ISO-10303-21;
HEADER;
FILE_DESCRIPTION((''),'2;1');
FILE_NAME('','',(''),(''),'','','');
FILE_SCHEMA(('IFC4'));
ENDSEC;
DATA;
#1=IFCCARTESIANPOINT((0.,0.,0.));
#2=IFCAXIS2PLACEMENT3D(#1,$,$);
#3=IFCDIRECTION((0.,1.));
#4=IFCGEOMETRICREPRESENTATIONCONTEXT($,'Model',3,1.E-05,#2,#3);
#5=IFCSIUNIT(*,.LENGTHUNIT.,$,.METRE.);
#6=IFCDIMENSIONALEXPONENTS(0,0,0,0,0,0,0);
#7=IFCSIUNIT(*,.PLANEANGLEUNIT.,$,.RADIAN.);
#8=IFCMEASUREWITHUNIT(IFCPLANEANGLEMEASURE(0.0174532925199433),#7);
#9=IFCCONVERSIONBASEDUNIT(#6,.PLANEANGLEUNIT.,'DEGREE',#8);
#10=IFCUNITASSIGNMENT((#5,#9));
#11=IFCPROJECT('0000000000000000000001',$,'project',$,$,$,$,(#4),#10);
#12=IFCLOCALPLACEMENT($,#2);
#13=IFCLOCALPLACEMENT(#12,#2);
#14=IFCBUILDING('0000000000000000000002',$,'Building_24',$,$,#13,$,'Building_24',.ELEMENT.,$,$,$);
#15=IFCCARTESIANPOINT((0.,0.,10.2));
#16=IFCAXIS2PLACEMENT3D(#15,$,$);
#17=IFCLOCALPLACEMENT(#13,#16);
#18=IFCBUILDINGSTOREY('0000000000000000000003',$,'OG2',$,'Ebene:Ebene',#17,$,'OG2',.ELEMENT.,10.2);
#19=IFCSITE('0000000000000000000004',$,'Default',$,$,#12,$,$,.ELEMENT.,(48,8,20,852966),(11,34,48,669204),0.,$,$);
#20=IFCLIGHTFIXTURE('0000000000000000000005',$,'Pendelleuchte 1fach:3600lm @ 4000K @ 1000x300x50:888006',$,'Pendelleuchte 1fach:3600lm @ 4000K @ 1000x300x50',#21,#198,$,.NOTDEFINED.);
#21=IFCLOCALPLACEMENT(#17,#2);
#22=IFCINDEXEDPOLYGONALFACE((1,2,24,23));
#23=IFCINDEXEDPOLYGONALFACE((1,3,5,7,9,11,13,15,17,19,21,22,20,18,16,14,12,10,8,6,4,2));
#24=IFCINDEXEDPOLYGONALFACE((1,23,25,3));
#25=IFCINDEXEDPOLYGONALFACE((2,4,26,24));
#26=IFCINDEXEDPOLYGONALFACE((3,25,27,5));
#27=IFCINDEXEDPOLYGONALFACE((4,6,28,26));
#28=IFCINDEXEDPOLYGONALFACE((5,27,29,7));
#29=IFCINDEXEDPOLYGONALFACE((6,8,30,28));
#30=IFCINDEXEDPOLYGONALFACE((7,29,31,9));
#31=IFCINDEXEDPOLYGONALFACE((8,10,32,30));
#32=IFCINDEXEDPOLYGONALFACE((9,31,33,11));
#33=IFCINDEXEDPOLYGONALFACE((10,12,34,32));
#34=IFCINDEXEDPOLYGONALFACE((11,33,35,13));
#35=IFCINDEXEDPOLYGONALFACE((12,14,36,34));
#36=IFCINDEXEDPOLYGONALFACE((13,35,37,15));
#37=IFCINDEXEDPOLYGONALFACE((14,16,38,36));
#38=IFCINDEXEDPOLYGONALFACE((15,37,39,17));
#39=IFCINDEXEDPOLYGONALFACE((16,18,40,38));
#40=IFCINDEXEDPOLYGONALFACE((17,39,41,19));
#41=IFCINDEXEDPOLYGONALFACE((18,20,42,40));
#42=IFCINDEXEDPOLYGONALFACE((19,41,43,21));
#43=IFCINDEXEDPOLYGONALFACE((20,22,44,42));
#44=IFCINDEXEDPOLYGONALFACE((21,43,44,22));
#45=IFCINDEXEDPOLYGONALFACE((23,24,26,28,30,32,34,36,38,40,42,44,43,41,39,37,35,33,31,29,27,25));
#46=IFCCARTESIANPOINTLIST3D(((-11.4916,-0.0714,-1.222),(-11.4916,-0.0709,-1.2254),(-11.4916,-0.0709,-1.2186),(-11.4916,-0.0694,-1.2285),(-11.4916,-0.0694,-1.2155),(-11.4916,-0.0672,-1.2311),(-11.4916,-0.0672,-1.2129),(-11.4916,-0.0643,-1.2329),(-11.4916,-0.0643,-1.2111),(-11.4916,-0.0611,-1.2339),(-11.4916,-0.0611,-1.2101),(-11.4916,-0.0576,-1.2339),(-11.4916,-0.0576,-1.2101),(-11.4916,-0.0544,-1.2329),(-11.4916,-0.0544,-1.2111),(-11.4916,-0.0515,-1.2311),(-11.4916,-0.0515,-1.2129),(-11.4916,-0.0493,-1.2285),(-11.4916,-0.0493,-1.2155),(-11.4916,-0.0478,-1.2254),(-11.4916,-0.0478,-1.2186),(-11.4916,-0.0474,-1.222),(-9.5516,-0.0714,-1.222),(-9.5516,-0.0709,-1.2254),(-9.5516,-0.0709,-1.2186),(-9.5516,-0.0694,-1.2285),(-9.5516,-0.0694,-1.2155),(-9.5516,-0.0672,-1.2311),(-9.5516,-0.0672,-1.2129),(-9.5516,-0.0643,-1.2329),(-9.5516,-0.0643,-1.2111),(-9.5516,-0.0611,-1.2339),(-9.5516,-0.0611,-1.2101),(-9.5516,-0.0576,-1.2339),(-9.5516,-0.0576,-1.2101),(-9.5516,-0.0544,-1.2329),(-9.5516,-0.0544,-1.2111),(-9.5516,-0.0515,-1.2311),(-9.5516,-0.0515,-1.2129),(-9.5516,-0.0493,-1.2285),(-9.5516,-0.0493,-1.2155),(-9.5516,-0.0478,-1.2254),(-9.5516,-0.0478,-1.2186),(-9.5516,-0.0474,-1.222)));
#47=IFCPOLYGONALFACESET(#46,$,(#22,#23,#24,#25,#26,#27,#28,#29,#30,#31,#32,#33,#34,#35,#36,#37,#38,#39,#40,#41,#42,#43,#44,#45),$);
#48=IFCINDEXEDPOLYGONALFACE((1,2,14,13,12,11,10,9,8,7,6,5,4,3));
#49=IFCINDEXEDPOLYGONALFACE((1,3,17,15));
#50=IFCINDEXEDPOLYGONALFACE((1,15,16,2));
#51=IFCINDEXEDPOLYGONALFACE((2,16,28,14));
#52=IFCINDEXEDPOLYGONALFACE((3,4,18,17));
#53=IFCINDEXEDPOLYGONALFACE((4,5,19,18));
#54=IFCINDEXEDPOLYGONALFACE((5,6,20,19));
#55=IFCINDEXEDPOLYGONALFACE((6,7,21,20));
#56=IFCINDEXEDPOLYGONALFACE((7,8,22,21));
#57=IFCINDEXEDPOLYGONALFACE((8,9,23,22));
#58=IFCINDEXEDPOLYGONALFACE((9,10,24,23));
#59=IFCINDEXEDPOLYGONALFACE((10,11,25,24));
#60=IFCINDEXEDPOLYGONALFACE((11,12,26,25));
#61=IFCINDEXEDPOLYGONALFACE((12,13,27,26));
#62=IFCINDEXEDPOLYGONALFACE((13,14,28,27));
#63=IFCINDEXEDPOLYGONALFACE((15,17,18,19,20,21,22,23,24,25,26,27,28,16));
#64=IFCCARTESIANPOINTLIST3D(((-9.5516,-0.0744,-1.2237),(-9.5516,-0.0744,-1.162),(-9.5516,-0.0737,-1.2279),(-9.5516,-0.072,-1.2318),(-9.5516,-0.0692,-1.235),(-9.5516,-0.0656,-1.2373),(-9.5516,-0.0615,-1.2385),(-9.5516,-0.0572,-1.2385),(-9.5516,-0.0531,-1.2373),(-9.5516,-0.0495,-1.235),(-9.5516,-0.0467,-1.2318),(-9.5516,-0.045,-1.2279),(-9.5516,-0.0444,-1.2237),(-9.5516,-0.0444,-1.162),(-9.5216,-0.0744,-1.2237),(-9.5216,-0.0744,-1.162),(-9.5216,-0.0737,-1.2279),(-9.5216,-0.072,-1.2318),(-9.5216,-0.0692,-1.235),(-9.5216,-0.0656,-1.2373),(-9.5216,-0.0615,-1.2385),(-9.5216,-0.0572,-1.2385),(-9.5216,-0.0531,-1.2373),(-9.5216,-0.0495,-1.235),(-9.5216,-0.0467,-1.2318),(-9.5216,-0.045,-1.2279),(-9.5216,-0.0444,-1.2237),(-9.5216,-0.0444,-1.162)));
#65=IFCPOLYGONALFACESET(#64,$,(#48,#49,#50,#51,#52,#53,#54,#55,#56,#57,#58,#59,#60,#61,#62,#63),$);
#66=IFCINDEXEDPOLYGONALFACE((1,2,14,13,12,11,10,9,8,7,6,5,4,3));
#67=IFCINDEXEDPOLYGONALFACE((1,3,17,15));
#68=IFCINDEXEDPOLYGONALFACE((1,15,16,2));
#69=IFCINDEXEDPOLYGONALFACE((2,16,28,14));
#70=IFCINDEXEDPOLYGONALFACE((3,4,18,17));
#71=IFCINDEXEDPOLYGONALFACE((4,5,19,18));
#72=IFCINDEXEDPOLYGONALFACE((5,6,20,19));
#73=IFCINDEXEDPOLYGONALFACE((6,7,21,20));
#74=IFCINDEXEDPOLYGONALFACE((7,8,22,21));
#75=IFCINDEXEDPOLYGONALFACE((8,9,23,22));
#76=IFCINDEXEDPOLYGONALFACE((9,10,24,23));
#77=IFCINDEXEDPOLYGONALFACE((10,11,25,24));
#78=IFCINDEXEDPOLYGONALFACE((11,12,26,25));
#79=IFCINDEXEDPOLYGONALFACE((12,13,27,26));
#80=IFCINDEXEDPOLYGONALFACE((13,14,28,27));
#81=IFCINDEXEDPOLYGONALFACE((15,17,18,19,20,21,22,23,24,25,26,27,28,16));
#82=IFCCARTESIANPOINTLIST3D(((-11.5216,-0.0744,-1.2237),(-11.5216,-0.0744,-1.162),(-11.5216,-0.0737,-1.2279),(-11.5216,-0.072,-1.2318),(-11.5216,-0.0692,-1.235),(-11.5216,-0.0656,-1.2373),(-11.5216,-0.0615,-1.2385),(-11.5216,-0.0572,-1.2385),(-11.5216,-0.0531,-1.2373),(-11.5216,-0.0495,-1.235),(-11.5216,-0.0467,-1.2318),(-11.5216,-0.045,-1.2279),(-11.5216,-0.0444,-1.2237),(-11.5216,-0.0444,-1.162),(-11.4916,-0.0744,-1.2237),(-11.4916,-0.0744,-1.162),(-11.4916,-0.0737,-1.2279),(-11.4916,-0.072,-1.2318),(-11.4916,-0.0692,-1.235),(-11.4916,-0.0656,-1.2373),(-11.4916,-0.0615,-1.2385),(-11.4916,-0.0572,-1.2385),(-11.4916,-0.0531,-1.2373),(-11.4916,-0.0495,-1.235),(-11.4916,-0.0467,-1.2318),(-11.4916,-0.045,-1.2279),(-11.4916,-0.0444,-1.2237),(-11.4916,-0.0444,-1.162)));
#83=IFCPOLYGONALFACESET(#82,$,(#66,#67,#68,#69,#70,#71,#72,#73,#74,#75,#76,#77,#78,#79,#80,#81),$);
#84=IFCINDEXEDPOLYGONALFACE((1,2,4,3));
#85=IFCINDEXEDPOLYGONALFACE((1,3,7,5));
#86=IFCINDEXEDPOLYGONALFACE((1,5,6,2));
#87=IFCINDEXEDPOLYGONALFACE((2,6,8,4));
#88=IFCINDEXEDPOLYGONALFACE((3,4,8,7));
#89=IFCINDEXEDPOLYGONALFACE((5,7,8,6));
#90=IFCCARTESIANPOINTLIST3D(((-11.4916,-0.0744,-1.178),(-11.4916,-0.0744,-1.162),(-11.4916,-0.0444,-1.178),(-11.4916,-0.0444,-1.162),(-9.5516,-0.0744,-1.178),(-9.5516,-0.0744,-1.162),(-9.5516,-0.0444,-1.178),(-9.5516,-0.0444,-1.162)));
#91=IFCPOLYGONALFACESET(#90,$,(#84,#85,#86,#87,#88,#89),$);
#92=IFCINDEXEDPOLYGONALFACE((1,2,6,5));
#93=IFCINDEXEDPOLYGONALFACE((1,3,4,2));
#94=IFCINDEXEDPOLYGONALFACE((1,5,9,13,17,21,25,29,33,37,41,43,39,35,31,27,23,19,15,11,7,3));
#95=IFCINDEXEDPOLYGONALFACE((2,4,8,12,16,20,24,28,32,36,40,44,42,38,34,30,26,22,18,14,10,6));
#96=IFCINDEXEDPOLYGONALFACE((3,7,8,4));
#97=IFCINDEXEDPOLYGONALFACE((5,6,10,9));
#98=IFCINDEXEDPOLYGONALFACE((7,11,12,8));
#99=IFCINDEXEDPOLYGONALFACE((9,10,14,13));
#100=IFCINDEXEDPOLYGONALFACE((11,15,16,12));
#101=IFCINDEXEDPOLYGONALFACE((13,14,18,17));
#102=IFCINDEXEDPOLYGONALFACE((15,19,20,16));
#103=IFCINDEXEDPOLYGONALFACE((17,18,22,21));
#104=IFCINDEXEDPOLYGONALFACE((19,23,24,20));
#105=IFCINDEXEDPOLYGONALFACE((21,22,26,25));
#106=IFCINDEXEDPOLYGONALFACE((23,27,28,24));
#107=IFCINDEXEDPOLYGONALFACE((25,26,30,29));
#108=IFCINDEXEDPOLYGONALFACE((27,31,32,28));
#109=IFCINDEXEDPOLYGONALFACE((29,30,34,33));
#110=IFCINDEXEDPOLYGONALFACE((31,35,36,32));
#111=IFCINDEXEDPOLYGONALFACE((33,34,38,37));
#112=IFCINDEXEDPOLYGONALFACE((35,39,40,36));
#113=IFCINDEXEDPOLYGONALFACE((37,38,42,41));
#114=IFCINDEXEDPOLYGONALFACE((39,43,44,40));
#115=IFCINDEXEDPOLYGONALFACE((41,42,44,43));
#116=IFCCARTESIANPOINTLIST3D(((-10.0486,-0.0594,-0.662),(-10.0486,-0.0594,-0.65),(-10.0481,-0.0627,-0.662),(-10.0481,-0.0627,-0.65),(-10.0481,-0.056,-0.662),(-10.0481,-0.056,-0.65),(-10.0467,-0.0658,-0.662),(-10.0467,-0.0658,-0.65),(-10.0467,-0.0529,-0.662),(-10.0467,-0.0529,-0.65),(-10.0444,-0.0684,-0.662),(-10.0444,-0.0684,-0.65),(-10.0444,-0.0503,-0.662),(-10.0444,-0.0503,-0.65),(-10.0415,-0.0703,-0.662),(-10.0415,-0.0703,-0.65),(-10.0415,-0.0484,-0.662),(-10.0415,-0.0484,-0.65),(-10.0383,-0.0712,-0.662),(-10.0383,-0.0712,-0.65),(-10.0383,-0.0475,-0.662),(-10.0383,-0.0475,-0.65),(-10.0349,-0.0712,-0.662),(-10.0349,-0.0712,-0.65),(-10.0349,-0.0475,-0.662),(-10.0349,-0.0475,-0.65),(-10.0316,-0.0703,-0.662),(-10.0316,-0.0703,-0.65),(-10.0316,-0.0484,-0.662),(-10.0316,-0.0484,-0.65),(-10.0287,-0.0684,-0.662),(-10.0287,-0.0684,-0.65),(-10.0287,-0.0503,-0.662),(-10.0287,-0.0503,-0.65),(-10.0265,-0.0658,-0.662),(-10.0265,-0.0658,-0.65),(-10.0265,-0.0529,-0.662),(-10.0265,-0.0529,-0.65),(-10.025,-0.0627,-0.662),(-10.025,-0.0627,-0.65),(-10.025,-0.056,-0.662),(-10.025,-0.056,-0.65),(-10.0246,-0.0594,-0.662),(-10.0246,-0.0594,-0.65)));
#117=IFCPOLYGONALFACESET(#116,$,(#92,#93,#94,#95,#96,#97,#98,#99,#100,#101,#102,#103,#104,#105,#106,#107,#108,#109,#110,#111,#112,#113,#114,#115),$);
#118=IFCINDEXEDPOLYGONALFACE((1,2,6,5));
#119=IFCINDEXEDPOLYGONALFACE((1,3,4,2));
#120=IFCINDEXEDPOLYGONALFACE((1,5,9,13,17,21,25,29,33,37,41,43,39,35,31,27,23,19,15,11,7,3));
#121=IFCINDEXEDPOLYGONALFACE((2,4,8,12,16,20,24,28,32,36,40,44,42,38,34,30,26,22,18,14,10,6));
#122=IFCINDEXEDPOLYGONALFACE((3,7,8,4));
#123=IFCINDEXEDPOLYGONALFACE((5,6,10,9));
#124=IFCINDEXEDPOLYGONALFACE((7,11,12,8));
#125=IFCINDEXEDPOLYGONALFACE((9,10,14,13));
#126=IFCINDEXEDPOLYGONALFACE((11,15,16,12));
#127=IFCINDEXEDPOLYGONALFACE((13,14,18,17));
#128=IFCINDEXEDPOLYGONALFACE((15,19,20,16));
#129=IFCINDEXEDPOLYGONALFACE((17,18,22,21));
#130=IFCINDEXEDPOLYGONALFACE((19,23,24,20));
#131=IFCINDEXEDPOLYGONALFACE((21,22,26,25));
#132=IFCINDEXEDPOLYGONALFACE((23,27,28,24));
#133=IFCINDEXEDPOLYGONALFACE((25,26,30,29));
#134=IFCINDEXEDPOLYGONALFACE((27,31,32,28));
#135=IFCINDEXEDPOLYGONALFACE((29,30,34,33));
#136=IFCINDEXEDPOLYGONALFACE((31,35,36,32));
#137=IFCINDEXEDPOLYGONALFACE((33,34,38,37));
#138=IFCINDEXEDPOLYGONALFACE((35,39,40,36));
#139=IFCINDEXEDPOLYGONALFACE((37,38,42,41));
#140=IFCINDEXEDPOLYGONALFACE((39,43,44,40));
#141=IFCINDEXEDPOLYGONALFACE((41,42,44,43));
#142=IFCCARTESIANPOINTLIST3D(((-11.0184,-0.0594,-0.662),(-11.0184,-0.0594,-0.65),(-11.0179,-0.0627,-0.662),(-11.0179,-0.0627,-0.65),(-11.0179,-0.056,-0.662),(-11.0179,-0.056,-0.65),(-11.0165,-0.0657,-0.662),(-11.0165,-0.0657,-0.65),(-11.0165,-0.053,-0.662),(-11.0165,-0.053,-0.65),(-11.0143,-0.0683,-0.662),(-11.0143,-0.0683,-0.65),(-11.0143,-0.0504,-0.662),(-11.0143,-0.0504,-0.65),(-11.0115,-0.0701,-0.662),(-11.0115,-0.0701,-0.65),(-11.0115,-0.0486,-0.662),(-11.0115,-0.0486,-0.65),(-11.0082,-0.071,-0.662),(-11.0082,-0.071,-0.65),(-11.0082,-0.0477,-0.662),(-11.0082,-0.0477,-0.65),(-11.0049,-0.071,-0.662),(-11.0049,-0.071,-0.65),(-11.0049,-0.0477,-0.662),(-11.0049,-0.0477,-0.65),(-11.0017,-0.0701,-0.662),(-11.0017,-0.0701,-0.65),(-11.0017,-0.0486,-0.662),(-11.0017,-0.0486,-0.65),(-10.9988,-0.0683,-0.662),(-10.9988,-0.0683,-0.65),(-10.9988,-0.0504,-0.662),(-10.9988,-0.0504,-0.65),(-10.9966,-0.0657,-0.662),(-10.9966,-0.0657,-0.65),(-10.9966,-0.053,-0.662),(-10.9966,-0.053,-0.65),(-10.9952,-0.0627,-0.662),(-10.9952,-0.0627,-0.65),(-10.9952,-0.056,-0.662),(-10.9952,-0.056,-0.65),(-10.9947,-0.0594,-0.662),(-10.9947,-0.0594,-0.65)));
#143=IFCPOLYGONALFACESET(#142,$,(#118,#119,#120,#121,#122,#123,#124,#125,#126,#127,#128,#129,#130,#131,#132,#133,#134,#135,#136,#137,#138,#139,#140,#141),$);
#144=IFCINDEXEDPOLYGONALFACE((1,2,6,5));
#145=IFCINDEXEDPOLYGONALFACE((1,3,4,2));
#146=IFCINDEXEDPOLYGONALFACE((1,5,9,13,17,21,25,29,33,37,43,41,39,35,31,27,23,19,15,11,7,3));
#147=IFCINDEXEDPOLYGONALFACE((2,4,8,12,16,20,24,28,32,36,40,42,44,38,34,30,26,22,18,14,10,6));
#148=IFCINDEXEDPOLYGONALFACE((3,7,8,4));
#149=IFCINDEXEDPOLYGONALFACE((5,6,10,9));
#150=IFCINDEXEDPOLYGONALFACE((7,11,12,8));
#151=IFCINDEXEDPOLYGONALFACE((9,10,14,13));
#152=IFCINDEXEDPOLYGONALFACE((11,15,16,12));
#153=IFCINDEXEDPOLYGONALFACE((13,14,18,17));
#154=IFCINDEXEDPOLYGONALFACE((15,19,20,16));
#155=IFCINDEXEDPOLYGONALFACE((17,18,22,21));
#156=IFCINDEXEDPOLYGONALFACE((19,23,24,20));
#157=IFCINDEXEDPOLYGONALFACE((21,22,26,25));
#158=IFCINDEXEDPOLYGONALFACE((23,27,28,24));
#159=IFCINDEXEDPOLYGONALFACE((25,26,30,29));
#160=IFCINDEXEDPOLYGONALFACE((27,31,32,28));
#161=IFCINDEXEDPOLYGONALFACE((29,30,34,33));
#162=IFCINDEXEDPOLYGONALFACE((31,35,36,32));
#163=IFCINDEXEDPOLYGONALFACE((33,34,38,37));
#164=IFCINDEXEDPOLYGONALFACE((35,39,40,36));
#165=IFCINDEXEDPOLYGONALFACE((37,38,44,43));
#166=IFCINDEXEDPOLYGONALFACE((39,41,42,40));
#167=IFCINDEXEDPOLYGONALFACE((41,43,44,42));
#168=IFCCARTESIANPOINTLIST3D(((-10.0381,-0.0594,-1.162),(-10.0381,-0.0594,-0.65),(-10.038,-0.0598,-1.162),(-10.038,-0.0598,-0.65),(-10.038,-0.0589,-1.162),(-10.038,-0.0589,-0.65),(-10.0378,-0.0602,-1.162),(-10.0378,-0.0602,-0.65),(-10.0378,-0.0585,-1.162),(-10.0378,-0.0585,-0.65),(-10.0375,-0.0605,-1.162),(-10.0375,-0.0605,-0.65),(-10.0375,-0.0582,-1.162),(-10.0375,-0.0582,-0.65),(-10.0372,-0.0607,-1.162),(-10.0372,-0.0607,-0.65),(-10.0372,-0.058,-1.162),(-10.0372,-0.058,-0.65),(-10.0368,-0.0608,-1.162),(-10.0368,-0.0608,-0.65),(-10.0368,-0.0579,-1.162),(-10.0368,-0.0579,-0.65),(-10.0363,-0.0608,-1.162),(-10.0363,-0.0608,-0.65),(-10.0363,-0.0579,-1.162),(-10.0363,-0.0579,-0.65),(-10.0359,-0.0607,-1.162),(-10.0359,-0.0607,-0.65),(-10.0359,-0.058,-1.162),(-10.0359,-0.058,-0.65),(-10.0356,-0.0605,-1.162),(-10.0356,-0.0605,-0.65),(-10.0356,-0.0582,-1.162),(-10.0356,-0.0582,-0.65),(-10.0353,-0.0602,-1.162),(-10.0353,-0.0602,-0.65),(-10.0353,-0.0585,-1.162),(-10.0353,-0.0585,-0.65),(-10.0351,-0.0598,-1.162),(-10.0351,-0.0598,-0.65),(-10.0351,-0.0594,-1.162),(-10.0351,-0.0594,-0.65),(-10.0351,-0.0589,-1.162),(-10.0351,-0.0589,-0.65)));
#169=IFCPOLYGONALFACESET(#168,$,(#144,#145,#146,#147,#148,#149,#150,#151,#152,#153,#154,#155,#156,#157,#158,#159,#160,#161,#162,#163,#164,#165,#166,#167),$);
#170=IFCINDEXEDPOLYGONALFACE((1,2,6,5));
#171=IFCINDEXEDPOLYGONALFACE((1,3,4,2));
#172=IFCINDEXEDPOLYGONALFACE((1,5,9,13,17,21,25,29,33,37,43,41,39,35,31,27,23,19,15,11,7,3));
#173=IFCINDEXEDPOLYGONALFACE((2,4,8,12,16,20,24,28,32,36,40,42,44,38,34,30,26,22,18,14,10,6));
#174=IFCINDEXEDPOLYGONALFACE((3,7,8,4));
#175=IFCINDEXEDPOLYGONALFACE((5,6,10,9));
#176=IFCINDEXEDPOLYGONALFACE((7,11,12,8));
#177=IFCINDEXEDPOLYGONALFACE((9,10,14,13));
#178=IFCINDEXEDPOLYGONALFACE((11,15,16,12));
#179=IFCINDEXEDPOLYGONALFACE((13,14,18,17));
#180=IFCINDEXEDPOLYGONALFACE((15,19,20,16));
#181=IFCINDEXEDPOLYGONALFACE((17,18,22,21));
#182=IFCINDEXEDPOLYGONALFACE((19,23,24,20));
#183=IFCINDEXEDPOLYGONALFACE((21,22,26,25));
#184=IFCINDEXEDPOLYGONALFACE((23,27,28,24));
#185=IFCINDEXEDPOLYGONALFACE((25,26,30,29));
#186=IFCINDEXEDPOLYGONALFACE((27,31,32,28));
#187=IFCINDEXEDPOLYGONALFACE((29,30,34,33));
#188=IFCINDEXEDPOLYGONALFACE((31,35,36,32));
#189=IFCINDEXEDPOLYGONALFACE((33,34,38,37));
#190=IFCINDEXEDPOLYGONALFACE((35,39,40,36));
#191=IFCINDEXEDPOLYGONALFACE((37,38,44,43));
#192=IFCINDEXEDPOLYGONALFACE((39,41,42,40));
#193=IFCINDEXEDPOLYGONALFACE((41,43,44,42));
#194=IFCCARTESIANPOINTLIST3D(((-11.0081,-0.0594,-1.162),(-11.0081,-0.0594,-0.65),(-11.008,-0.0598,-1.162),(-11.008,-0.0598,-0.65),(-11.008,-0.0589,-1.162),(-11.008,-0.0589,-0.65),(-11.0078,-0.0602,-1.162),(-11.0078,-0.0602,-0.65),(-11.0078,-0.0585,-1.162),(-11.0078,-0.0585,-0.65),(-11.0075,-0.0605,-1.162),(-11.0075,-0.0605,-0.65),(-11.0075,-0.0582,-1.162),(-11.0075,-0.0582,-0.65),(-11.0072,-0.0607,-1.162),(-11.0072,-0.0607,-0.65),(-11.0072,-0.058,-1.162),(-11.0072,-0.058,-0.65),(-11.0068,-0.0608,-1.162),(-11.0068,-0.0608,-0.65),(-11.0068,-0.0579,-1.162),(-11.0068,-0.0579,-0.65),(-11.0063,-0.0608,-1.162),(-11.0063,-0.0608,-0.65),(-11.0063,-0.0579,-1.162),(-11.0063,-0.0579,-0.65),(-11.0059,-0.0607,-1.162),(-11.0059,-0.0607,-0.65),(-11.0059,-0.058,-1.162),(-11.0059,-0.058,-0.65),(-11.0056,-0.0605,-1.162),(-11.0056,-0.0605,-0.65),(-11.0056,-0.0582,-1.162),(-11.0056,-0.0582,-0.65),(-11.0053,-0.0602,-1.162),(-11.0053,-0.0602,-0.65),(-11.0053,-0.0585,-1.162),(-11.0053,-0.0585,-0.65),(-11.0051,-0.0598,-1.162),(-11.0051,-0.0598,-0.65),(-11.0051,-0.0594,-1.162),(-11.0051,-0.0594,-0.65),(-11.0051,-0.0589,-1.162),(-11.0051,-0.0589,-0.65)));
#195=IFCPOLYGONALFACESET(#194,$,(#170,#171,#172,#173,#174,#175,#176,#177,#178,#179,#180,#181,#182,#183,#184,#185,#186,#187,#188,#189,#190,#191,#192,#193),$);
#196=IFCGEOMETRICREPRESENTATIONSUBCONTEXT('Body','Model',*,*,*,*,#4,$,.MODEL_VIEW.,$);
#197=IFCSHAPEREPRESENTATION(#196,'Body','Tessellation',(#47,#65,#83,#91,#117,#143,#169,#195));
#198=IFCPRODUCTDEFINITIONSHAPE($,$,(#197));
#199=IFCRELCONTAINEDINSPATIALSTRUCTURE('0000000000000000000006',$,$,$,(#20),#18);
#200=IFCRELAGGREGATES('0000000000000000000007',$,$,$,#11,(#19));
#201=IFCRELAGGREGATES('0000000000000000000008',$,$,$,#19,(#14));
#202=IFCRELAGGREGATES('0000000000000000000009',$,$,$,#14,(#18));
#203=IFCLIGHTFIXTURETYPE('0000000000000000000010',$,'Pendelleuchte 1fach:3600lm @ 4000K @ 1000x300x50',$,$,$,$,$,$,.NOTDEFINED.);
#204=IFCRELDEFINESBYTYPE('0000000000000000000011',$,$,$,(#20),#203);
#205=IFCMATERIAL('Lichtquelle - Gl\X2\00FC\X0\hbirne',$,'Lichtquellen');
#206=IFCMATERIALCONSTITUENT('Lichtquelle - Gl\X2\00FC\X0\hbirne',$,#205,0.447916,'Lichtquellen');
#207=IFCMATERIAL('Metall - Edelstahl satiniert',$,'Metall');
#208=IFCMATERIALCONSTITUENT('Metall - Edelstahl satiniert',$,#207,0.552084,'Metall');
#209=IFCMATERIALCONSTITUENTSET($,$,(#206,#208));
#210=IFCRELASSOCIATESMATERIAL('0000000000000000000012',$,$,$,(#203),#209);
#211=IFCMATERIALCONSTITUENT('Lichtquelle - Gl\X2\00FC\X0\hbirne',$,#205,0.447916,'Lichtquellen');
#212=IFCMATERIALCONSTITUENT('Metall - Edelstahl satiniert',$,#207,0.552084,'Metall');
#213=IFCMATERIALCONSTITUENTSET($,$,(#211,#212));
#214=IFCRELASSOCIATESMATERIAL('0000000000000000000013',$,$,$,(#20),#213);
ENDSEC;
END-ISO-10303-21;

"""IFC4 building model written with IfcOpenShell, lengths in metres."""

from ifc_helpers import new_model, entity, si_unit, converted_unit, direction, frame, origin, place, context, subcontext, project, spatial, line, arc, indexed_curve, outline, extrude, source, transform, mapped, material, constituent, constituent_set, type_object, type_shapes, element, save


model = new_model("IFC4")

# Units and contexts
model_context = context("Model", 3, precision=1e-05, world=origin(), true_north=direction((0.0, 1.0)))
body_context = subcontext(model_context, "Body", "Model", "MODEL_VIEW")
ifc_project = project(units=[si_unit("LENGTHUNIT", "METRE"), converted_unit("PLANEANGLEUNIT", "DEGREE", entity("IfcPlaneAngleMeasure", 0.0174532925199433), si_unit("PLANEANGLEUNIT", "RADIAN"), dimensions=[0, 0, 0, 0, 0, 0, 0])], contexts=[model_context])

# Site, building, storey
site_placement = place(None, origin())
site = spatial("IfcSite", under=ifc_project, at=site_placement, Name="Default", CompositionType="ELEMENT", RefLatitude=(48, 8, 20, 852966), RefLongitude=(11, 34, 48, 669204), RefElevation=0.0)
building_placement = place(site_placement, origin())
building = spatial("IfcBuilding", under=site, at=building_placement, Name="Building_24", LongName="Building_24", CompositionType="ELEMENT")
storey_placement = place(building_placement, frame((0.0, 0.0, 10.2)))
storey = spatial("IfcBuildingStorey", under=building, at=storey_placement, Name="OG2", ObjectType="Ebene:Ebene", LongName="OG2", CompositionType="ELEMENT", Elevation=10.2)

# Light fixture
ifc_material_1 = material(Name="Lichtquelle - Glühbirne", Category="Lichtquellen")
ifc_material_2 = material(Name="Metall - Edelstahl satiniert", Category="Metall")
ifc_constituent_1 = constituent(ifc_material_1, Name="Lichtquelle - Glühbirne", Category="Lichtquellen", fraction=0.447916)
ifc_constituent_2 = constituent(ifc_material_2, Name="Metall - Edelstahl satiniert", Category="Metall", fraction=0.552084)
ifc_constituent_set_1 = constituent_set(constituents=[ifc_constituent_1, ifc_constituent_2])
light_fixture_type_1 = type_object("IfcLightFixtureType", Name="Pendelleuchte 1fach:3600lm @ 4000K @ 1000x300x50", PredefinedType="NOTDEFINED", material=ifc_constituent_set_1)
shared_shape_1 = source(origin(), body_context, "Body", "SweptSolid", [
    extrude(outline(indexed_curve([(-0.012, 0.0), (0.0, -0.012), (0.012, 0.0), (0.0, 0.012)], segments=[arc(1, 2, 3), arc(3, 4, 1)], self_intersect=False)), frame((-0.97, 0.0, -0.572), z_axis=(1.0, 0.0, 0.0), x_axis=(0.0, 1.0, 0.0)), (0.0, 0.0, 1.0), 1.94),
    extrude(outline(indexed_curve([(-0.0308, -0.015), (0.0308, -0.015), (0.0308, 0.015), (-0.0308, 0.015), (-0.0458, 0.0)], segments=[line(1, 2, 3, 4), arc(4, 5, 1)], self_intersect=False)), frame((0.97, 0.0, -0.5428), z_axis=(1.0, 0.0, 0.0), x_axis=(0.0, 0.0, 1.0)), (0.0, 0.0, 1.0), 0.03),
    extrude(outline(indexed_curve([(-0.0308, -0.015), (0.0308, -0.015), (0.0308, 0.015), (-0.0308, 0.015), (-0.0458, 0.0)], segments=[line(1, 2, 3, 4), arc(4, 5, 1)], self_intersect=False)), frame((-1.0, 0.0, -0.5428), z_axis=(1.0, 0.0, 0.0), x_axis=(0.0, 0.0, 1.0)), (0.0, 0.0, 1.0), 0.03),
    extrude(outline(indexed_curve([(-0.97, -0.015), (0.97, -0.015), (0.97, 0.015), (-0.97, 0.015), (-0.97, -0.015)], self_intersect=False)), frame((0.0, 0.0, -0.528), z_axis=(0.0, 0.0, 1.0), x_axis=(-1.0, 0.0, 0.0)), (0.0, 0.0, 1.0), 0.016),
    extrude(outline(indexed_curve([(-0.012, 0.0), (0.0, -0.012), (0.012, 0.0), (0.0, 0.012)], segments=[arc(1, 2, 3), arc(3, 4, 1)], self_intersect=False)), frame((0.485, 0.0, -0.012)), (0.0, 0.0, 1.0), 0.012),
    extrude(outline(indexed_curve([(-0.0118, 0.0), (0.0, -0.0118), (0.0118, 0.0), (0.0, 0.0118)], segments=[arc(1, 2, 3), arc(3, 4, 1)], self_intersect=False)), frame((-0.485, 0.0, -0.012)), (0.0, 0.0, 1.0), 0.012),
    extrude(outline(indexed_curve([(-0.0015, 0.0), (0.0, -0.0015), (0.0015, 0.0), (0.0, 0.0015)], segments=[arc(1, 2, 3), arc(3, 4, 1)], self_intersect=False)), frame((0.485, 0.0, -0.512)), (0.0, 0.0, 1.0), 0.512),
    extrude(outline(indexed_curve([(-0.0015, 0.0), (0.0, -0.0015), (0.0015, 0.0), (0.0, 0.0015)], segments=[arc(1, 2, 3), arc(3, 4, 1)], self_intersect=False)), frame((-0.485, 0.0, -0.512)), (0.0, 0.0, 1.0), 0.512),
])
type_shapes(light_fixture_type_1, [shared_shape_1])
ifc_constituent_3 = constituent(ifc_material_1, Name="Lichtquelle - Glühbirne", Category="Lichtquellen", fraction=0.447916)
ifc_constituent_4 = constituent(ifc_material_2, Name="Metall - Edelstahl satiniert", Category="Metall", fraction=0.552084)
ifc_constituent_set_2 = constituent_set(constituents=[ifc_constituent_3, ifc_constituent_4])
light_fixture_1_placement = place(storey_placement, frame((-10.5216, -0.0594, -0.65)))
element("IfcLightFixture", 1, at=light_fixture_1_placement, inside=storey, type_object=light_fixture_type_1, material=ifc_constituent_set_2, Name="Pendelleuchte 1fach:3600lm @ 4000K @ 1000x300x50:888006", ObjectType="Pendelleuchte 1fach:3600lm @ 4000K @ 1000x300x50", PredefinedType="NOTDEFINED", context=body_context, shape_type="MappedRepresentation", body=[
    mapped(shared_shape_1, transform((0.0, 0.0, 0.0), scale=1.0)),
])

save(model, "model.ifc")
